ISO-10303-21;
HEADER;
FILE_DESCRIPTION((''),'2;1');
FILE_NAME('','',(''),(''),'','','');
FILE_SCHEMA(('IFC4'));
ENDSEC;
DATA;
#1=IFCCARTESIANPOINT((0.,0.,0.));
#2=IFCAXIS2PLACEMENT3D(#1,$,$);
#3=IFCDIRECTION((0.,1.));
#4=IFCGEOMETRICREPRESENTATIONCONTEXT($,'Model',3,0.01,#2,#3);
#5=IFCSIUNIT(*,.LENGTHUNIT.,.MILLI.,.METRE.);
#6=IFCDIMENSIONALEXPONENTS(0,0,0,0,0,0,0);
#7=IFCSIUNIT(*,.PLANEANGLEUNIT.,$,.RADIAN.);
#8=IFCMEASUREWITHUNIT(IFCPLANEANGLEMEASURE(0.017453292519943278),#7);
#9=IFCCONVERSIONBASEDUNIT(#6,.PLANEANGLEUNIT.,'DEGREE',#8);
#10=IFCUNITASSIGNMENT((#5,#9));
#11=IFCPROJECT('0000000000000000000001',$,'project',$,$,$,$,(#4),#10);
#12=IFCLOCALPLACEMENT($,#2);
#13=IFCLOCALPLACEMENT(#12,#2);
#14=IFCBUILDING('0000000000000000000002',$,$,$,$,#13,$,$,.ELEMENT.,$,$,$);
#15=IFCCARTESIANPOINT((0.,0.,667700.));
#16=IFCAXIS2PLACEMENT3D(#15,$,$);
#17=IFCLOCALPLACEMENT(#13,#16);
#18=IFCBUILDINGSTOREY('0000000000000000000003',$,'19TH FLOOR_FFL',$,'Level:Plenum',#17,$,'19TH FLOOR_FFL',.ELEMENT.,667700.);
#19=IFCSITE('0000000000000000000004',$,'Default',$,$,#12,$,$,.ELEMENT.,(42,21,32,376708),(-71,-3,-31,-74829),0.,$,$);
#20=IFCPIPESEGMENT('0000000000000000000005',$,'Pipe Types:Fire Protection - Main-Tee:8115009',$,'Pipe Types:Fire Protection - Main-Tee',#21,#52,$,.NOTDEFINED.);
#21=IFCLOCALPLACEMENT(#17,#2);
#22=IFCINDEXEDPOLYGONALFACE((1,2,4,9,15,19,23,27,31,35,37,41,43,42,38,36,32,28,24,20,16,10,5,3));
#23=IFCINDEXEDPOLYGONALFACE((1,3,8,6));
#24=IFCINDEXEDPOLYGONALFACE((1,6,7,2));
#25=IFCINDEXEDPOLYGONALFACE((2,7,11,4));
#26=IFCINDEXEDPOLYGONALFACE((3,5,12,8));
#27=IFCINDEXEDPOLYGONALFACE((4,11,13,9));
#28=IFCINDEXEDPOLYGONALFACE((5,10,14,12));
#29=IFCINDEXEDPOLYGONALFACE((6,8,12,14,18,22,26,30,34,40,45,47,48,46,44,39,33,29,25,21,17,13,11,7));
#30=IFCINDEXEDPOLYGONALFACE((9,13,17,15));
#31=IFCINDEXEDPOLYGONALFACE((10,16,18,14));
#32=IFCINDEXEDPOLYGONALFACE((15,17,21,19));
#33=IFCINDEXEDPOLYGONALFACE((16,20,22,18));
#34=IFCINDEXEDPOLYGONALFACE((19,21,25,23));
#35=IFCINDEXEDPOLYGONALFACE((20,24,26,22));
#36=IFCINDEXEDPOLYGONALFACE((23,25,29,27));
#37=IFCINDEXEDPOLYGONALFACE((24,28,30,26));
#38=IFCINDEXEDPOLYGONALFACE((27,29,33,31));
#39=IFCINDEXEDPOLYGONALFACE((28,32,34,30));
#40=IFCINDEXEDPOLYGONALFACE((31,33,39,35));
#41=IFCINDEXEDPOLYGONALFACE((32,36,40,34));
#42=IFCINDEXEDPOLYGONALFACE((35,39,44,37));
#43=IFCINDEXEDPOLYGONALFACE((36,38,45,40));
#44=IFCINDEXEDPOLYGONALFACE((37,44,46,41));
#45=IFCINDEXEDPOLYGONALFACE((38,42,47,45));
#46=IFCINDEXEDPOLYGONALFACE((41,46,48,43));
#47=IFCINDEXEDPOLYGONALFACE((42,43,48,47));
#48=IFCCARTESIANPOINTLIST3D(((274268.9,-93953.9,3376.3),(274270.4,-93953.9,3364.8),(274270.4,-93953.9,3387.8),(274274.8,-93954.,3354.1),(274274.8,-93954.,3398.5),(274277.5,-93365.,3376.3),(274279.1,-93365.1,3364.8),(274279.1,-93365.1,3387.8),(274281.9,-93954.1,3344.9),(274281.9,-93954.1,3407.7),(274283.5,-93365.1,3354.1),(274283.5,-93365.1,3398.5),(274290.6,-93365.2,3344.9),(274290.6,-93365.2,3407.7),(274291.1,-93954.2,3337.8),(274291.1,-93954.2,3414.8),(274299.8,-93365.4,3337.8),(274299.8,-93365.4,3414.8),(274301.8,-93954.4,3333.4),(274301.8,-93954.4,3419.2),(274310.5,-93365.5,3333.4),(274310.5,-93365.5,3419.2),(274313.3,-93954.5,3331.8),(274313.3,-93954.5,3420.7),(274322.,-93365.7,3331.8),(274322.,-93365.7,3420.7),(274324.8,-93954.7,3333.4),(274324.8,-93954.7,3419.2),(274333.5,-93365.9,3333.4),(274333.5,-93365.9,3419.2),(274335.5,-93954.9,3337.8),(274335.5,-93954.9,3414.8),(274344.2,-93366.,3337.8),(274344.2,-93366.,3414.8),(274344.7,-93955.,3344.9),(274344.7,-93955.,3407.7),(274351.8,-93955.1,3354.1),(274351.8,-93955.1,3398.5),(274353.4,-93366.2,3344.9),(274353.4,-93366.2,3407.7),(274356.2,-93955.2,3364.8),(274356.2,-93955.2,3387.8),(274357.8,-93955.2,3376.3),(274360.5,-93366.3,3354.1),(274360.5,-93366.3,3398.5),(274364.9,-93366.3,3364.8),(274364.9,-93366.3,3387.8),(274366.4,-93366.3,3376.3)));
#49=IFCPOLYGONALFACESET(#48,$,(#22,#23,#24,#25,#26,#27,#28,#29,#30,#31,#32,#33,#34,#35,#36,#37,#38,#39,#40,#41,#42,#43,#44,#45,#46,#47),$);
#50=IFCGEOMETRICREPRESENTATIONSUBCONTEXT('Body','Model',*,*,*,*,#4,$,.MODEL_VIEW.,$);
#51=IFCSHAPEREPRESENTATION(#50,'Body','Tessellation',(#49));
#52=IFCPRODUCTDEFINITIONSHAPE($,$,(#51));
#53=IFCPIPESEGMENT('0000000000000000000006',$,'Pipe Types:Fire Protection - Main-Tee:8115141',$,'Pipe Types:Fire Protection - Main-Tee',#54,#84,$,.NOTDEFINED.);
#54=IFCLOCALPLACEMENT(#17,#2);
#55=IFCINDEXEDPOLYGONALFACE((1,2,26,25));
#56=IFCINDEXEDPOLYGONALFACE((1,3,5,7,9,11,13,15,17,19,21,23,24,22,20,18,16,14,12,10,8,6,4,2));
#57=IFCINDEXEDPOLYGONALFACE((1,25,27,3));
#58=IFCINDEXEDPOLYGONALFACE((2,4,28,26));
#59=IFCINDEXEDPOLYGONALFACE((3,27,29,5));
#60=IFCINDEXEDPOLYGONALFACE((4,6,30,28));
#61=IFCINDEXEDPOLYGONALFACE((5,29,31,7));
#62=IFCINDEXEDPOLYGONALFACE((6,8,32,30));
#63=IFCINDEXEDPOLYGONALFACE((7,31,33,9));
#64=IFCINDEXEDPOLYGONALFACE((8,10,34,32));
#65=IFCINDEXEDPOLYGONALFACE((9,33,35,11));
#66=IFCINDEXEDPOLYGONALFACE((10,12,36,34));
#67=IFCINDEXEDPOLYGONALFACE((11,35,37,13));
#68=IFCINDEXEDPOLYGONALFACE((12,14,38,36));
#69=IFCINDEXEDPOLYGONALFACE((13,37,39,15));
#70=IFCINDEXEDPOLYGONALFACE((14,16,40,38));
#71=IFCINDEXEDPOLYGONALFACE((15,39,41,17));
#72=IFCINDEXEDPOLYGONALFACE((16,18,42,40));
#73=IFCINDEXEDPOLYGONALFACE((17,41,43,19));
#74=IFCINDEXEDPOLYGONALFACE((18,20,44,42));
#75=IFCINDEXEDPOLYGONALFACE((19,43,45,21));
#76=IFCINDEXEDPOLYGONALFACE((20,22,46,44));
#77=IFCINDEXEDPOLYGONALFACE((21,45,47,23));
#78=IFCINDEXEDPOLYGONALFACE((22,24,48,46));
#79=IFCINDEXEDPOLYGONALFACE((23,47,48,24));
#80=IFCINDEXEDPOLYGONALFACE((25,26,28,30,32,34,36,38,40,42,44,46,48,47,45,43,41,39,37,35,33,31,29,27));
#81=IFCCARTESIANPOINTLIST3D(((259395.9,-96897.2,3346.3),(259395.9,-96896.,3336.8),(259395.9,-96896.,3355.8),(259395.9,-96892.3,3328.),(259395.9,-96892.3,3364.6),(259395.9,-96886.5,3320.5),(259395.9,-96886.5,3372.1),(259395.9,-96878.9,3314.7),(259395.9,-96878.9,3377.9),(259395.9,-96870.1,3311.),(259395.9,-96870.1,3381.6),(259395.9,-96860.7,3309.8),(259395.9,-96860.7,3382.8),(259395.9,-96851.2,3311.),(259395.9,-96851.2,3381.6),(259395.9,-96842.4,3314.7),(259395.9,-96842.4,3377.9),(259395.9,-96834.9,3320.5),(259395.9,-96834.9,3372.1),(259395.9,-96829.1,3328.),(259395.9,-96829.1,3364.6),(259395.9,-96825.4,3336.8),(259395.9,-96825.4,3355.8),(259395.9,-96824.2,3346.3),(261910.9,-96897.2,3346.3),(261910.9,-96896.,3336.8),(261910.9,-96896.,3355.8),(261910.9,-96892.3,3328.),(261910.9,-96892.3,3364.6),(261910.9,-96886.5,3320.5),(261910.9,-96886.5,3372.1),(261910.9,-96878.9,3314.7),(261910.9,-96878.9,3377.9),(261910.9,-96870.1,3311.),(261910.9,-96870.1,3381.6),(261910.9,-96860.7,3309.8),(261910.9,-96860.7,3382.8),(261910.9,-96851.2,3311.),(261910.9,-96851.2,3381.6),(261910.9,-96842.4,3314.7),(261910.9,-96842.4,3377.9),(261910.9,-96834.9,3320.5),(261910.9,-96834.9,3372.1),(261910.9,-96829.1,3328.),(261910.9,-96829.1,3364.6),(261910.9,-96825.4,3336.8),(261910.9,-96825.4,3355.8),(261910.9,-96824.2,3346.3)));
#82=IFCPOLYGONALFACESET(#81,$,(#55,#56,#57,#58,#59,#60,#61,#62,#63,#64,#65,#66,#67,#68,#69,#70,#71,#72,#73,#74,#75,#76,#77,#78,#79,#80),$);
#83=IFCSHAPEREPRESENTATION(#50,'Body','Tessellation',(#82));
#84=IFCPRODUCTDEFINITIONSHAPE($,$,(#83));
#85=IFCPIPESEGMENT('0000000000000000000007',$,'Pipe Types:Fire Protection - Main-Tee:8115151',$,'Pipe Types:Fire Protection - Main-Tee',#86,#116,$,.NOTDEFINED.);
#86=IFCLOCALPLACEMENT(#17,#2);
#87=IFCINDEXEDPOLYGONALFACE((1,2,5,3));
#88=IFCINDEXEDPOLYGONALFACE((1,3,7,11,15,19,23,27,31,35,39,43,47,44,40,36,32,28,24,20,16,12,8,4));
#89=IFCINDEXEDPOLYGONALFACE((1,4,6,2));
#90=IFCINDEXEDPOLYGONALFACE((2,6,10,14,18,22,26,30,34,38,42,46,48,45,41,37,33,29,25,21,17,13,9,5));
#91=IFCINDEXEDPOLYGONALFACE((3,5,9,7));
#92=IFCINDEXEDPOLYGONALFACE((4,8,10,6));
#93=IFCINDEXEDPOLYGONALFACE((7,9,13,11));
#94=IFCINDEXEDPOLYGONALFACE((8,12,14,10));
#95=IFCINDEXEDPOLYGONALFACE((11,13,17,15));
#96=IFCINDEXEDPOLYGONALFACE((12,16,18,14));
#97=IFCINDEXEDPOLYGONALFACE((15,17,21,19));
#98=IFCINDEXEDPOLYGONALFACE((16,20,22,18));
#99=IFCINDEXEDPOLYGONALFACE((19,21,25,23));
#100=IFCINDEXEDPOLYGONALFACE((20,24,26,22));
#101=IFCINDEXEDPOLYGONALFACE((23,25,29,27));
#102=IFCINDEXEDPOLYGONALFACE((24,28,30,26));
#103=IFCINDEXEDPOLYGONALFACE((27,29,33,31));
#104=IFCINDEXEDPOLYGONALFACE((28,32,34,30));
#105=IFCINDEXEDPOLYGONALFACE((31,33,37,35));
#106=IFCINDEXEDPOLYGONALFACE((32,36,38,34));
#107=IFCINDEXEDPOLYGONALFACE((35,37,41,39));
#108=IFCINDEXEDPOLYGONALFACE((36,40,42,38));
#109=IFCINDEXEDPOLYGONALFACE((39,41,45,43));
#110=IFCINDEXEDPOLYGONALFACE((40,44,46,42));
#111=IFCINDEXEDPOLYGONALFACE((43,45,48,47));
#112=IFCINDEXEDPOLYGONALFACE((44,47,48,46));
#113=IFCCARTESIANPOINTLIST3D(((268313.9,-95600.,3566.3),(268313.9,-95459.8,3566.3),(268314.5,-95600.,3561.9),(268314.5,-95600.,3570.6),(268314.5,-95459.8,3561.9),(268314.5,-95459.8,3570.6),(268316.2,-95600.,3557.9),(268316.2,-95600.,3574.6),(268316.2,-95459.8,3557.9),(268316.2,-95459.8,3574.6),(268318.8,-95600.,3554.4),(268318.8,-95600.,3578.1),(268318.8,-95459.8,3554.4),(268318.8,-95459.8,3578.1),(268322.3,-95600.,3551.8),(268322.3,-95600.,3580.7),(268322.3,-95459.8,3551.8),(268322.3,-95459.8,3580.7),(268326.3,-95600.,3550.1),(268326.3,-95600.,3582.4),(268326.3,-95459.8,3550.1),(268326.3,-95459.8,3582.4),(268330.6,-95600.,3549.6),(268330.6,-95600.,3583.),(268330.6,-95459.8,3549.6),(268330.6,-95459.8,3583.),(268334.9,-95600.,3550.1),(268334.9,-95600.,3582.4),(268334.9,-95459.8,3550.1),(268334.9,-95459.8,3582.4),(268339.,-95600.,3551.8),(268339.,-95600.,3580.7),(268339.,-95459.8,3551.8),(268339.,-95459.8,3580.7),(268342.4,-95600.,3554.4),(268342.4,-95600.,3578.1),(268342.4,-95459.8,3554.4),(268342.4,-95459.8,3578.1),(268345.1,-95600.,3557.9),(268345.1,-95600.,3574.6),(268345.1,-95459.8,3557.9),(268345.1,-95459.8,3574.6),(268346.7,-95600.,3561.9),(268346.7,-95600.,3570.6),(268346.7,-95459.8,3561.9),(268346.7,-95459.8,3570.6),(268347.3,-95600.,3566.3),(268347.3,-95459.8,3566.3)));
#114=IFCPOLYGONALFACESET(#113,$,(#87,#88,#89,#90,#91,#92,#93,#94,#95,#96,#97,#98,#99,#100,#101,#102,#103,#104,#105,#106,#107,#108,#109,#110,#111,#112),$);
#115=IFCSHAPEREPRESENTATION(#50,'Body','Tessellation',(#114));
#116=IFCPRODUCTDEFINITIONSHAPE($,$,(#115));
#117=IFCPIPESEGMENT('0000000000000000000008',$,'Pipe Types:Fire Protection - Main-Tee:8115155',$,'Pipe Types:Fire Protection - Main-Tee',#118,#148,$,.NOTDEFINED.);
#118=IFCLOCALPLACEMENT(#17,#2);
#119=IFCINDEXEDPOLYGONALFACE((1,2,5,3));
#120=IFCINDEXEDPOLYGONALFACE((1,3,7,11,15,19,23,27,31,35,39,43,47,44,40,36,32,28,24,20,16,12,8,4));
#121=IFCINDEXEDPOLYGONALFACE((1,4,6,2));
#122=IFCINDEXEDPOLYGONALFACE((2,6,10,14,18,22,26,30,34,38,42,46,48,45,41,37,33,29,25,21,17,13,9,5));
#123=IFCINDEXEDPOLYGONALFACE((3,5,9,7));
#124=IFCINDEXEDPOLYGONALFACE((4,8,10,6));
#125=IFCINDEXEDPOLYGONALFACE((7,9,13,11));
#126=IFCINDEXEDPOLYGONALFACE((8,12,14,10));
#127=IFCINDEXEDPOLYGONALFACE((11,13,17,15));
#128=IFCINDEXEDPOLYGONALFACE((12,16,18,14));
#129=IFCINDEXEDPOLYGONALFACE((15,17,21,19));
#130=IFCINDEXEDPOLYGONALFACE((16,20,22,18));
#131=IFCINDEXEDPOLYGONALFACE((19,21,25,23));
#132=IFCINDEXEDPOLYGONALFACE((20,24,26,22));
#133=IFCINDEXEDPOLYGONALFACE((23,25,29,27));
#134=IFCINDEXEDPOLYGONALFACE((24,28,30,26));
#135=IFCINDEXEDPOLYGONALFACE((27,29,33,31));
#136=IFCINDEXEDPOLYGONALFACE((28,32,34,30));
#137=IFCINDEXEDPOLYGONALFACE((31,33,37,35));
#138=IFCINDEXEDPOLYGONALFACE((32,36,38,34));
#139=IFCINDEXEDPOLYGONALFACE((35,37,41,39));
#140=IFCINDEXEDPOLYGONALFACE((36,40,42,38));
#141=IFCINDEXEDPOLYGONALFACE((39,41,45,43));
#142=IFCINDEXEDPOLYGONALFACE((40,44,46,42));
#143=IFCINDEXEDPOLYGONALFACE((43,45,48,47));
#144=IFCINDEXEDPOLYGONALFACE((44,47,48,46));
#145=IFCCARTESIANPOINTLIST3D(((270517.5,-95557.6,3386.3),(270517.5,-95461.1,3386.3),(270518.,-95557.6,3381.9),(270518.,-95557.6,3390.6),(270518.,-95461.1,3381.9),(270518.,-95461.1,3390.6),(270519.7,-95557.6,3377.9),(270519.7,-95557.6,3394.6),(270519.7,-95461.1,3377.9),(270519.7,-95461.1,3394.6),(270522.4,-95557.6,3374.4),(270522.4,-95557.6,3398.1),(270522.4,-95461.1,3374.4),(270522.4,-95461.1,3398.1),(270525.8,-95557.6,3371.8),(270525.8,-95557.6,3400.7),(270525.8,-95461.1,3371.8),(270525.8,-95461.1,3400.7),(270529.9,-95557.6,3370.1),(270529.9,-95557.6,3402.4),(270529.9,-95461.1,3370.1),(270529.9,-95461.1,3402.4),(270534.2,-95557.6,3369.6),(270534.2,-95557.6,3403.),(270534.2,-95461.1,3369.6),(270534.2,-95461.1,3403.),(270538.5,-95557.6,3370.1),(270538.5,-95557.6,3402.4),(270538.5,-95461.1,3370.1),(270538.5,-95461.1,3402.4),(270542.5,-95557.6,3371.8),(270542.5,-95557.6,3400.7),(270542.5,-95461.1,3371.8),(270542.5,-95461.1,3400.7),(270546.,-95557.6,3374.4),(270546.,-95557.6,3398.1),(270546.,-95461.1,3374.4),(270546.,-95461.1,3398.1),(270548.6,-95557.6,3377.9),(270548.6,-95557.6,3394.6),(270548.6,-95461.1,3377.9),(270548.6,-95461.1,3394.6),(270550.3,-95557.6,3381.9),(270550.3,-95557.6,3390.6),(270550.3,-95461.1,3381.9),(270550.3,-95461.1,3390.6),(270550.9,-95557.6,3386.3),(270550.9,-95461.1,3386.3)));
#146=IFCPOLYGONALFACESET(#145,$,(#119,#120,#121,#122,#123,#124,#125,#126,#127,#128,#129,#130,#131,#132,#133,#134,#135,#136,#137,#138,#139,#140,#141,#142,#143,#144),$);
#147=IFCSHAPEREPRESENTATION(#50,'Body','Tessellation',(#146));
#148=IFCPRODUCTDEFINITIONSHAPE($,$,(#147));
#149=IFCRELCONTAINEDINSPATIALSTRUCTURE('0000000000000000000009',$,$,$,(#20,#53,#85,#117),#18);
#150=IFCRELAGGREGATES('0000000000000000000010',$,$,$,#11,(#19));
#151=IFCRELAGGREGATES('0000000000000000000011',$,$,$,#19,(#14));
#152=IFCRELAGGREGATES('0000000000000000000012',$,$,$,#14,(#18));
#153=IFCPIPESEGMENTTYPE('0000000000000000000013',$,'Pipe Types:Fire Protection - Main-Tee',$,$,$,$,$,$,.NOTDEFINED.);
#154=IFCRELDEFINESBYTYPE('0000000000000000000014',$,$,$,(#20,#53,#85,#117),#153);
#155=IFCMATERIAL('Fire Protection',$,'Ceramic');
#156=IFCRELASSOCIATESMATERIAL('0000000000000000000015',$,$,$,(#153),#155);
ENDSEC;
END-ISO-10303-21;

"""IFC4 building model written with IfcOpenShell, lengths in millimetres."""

from ifc_helpers import new_model, entity, si_unit, converted_unit, direction, frame, origin, place, context, subcontext, project, spatial, arc, indexed_curve, outline, extrude, material, type_object, element, save


model = new_model("IFC4")

# Units and contexts
model_context = context("Model", 3, precision=0.01, world=origin(), true_north=direction((0.0, 1.0)))
body_context = subcontext(model_context, "Body", "Model", "MODEL_VIEW")
ifc_project = project(units=[si_unit("LENGTHUNIT", "METRE", prefix="MILLI"), converted_unit("PLANEANGLEUNIT", "DEGREE", entity("IfcPlaneAngleMeasure", 0.017453292519943278), si_unit("PLANEANGLEUNIT", "RADIAN"), dimensions=[0, 0, 0, 0, 0, 0, 0])], contexts=[model_context])

# Site, building, storey
site_placement = place(None, origin())
site = spatial("IfcSite", under=ifc_project, at=site_placement, Name="Default", CompositionType="ELEMENT", RefLatitude=(42, 21, 32, 376708), RefLongitude=(-71, -3, -31, -74829), RefElevation=0.0)
building_placement = place(site_placement, origin())
building = spatial("IfcBuilding", under=site, at=building_placement, CompositionType="ELEMENT")
storey_placement = place(building_placement, frame((0.0, 0.0, 667700.0)))
storey = spatial("IfcBuildingStorey", under=building, at=storey_placement, Name="19TH FLOOR_FFL", ObjectType="Level:Plenum", LongName="19TH FLOOR_FFL", CompositionType="ELEMENT", Elevation=667700.0)

# Pipe segments
ifc_material_1 = material(Name="Fire Protection", Category="Ceramic")
pipe_segment_type = type_object("IfcPipeSegmentType", Name="Pipe Types:Fire Protection - Main-Tee", PredefinedType="NOTDEFINED", material=ifc_material_1)
pipe_segment_1_placement = place(storey_placement, origin())
element("IfcPipeSegment", 1, at=pipe_segment_1_placement, inside=storey, type_object=pipe_segment_type, Name="Pipe Types:Fire Protection - Main-Tee:8115009", ObjectType="Pipe Types:Fire Protection - Main-Tee", PredefinedType="NOTDEFINED", context=body_context, shape_type="SweptSolid", body=[
    extrude(outline(indexed_curve([(44.5, 0.0), (31.4, 31.4), (0.0, 44.5), (-31.4, 31.4), (-44.5, 0.0), (-31.4, -31.4), (0.0, -44.5), (31.4, -31.4)], segments=[arc(1, 2, 3), arc(3, 4, 5), arc(5, 6, 7), arc(7, 8, 1)], self_intersect=False)), frame((274313.3, -93954.5, 3376.3), z_axis=(0.014731, 0.999891, 0.0), x_axis=(0.999891, -0.014731, 0.0)), (0.0, 0.0, 1.0), 588.9),
])
pipe_segment_2_placement = place(storey_placement, origin())
element("IfcPipeSegment", 2, at=pipe_segment_2_placement, inside=storey, type_object=pipe_segment_type, Name="Pipe Types:Fire Protection - Main-Tee:8115141", ObjectType="Pipe Types:Fire Protection - Main-Tee", PredefinedType="NOTDEFINED", context=body_context, shape_type="SweptSolid", body=[
    extrude(outline(indexed_curve([(36.5, 0.0), (25.8, 25.8), (0.0, 36.5), (-25.8, 25.8), (-36.5, 0.0), (-25.8, -25.8), (0.0, -36.5), (25.8, -25.8)], segments=[arc(1, 2, 3), arc(3, 4, 5), arc(5, 6, 7), arc(7, 8, 1)], self_intersect=False)), frame((259395.9, -96860.7, 3346.3), z_axis=(1.0, 0.0, 0.0), x_axis=(0.0, -1.0, 0.0)), (0.0, 0.0, 1.0), 2515.1),
])
pipe_segment_3_placement = place(storey_placement, origin())
element("IfcPipeSegment", 3, at=pipe_segment_3_placement, inside=storey, type_object=pipe_segment_type, Name="Pipe Types:Fire Protection - Main-Tee:8115151", ObjectType="Pipe Types:Fire Protection - Main-Tee", PredefinedType="NOTDEFINED", context=body_context, shape_type="SweptSolid", body=[
    extrude(outline(indexed_curve([(16.7, 0.0), (11.8, 11.8), (0.0, 16.7), (-11.8, 11.8), (-16.7, 0.0), (-11.8, -11.8), (0.0, -16.7), (11.8, -11.8)], segments=[arc(1, 2, 3), arc(3, 4, 5), arc(5, 6, 7), arc(7, 8, 1)], self_intersect=False)), frame((268330.6, -95600.0, 3566.3), z_axis=(0.0, 1.0, 0.0), x_axis=(1.0, 0.0, 0.0)), (0.0, 0.0, 1.0), 140.2),
])
pipe_segment_4_placement = place(storey_placement, origin())
element("IfcPipeSegment", 4, at=pipe_segment_4_placement, inside=storey, type_object=pipe_segment_type, Name="Pipe Types:Fire Protection - Main-Tee:8115155", ObjectType="Pipe Types:Fire Protection - Main-Tee", PredefinedType="NOTDEFINED", context=body_context, shape_type="SweptSolid", body=[
    extrude(outline(indexed_curve([(16.7, 0.0), (11.8, 11.8), (0.0, 16.7), (-11.8, 11.8), (-16.7, 0.0), (-11.8, -11.8), (0.0, -16.7), (11.8, -11.8)], segments=[arc(1, 2, 3), arc(3, 4, 5), arc(5, 6, 7), arc(7, 8, 1)], self_intersect=False)), frame((270534.2, -95557.6, 3386.3), z_axis=(0.0, 1.0, 0.0), x_axis=(1.0, 0.0, 0.0)), (0.0, 0.0, 1.0), 96.6),
])

save(model, "model.ifc")
